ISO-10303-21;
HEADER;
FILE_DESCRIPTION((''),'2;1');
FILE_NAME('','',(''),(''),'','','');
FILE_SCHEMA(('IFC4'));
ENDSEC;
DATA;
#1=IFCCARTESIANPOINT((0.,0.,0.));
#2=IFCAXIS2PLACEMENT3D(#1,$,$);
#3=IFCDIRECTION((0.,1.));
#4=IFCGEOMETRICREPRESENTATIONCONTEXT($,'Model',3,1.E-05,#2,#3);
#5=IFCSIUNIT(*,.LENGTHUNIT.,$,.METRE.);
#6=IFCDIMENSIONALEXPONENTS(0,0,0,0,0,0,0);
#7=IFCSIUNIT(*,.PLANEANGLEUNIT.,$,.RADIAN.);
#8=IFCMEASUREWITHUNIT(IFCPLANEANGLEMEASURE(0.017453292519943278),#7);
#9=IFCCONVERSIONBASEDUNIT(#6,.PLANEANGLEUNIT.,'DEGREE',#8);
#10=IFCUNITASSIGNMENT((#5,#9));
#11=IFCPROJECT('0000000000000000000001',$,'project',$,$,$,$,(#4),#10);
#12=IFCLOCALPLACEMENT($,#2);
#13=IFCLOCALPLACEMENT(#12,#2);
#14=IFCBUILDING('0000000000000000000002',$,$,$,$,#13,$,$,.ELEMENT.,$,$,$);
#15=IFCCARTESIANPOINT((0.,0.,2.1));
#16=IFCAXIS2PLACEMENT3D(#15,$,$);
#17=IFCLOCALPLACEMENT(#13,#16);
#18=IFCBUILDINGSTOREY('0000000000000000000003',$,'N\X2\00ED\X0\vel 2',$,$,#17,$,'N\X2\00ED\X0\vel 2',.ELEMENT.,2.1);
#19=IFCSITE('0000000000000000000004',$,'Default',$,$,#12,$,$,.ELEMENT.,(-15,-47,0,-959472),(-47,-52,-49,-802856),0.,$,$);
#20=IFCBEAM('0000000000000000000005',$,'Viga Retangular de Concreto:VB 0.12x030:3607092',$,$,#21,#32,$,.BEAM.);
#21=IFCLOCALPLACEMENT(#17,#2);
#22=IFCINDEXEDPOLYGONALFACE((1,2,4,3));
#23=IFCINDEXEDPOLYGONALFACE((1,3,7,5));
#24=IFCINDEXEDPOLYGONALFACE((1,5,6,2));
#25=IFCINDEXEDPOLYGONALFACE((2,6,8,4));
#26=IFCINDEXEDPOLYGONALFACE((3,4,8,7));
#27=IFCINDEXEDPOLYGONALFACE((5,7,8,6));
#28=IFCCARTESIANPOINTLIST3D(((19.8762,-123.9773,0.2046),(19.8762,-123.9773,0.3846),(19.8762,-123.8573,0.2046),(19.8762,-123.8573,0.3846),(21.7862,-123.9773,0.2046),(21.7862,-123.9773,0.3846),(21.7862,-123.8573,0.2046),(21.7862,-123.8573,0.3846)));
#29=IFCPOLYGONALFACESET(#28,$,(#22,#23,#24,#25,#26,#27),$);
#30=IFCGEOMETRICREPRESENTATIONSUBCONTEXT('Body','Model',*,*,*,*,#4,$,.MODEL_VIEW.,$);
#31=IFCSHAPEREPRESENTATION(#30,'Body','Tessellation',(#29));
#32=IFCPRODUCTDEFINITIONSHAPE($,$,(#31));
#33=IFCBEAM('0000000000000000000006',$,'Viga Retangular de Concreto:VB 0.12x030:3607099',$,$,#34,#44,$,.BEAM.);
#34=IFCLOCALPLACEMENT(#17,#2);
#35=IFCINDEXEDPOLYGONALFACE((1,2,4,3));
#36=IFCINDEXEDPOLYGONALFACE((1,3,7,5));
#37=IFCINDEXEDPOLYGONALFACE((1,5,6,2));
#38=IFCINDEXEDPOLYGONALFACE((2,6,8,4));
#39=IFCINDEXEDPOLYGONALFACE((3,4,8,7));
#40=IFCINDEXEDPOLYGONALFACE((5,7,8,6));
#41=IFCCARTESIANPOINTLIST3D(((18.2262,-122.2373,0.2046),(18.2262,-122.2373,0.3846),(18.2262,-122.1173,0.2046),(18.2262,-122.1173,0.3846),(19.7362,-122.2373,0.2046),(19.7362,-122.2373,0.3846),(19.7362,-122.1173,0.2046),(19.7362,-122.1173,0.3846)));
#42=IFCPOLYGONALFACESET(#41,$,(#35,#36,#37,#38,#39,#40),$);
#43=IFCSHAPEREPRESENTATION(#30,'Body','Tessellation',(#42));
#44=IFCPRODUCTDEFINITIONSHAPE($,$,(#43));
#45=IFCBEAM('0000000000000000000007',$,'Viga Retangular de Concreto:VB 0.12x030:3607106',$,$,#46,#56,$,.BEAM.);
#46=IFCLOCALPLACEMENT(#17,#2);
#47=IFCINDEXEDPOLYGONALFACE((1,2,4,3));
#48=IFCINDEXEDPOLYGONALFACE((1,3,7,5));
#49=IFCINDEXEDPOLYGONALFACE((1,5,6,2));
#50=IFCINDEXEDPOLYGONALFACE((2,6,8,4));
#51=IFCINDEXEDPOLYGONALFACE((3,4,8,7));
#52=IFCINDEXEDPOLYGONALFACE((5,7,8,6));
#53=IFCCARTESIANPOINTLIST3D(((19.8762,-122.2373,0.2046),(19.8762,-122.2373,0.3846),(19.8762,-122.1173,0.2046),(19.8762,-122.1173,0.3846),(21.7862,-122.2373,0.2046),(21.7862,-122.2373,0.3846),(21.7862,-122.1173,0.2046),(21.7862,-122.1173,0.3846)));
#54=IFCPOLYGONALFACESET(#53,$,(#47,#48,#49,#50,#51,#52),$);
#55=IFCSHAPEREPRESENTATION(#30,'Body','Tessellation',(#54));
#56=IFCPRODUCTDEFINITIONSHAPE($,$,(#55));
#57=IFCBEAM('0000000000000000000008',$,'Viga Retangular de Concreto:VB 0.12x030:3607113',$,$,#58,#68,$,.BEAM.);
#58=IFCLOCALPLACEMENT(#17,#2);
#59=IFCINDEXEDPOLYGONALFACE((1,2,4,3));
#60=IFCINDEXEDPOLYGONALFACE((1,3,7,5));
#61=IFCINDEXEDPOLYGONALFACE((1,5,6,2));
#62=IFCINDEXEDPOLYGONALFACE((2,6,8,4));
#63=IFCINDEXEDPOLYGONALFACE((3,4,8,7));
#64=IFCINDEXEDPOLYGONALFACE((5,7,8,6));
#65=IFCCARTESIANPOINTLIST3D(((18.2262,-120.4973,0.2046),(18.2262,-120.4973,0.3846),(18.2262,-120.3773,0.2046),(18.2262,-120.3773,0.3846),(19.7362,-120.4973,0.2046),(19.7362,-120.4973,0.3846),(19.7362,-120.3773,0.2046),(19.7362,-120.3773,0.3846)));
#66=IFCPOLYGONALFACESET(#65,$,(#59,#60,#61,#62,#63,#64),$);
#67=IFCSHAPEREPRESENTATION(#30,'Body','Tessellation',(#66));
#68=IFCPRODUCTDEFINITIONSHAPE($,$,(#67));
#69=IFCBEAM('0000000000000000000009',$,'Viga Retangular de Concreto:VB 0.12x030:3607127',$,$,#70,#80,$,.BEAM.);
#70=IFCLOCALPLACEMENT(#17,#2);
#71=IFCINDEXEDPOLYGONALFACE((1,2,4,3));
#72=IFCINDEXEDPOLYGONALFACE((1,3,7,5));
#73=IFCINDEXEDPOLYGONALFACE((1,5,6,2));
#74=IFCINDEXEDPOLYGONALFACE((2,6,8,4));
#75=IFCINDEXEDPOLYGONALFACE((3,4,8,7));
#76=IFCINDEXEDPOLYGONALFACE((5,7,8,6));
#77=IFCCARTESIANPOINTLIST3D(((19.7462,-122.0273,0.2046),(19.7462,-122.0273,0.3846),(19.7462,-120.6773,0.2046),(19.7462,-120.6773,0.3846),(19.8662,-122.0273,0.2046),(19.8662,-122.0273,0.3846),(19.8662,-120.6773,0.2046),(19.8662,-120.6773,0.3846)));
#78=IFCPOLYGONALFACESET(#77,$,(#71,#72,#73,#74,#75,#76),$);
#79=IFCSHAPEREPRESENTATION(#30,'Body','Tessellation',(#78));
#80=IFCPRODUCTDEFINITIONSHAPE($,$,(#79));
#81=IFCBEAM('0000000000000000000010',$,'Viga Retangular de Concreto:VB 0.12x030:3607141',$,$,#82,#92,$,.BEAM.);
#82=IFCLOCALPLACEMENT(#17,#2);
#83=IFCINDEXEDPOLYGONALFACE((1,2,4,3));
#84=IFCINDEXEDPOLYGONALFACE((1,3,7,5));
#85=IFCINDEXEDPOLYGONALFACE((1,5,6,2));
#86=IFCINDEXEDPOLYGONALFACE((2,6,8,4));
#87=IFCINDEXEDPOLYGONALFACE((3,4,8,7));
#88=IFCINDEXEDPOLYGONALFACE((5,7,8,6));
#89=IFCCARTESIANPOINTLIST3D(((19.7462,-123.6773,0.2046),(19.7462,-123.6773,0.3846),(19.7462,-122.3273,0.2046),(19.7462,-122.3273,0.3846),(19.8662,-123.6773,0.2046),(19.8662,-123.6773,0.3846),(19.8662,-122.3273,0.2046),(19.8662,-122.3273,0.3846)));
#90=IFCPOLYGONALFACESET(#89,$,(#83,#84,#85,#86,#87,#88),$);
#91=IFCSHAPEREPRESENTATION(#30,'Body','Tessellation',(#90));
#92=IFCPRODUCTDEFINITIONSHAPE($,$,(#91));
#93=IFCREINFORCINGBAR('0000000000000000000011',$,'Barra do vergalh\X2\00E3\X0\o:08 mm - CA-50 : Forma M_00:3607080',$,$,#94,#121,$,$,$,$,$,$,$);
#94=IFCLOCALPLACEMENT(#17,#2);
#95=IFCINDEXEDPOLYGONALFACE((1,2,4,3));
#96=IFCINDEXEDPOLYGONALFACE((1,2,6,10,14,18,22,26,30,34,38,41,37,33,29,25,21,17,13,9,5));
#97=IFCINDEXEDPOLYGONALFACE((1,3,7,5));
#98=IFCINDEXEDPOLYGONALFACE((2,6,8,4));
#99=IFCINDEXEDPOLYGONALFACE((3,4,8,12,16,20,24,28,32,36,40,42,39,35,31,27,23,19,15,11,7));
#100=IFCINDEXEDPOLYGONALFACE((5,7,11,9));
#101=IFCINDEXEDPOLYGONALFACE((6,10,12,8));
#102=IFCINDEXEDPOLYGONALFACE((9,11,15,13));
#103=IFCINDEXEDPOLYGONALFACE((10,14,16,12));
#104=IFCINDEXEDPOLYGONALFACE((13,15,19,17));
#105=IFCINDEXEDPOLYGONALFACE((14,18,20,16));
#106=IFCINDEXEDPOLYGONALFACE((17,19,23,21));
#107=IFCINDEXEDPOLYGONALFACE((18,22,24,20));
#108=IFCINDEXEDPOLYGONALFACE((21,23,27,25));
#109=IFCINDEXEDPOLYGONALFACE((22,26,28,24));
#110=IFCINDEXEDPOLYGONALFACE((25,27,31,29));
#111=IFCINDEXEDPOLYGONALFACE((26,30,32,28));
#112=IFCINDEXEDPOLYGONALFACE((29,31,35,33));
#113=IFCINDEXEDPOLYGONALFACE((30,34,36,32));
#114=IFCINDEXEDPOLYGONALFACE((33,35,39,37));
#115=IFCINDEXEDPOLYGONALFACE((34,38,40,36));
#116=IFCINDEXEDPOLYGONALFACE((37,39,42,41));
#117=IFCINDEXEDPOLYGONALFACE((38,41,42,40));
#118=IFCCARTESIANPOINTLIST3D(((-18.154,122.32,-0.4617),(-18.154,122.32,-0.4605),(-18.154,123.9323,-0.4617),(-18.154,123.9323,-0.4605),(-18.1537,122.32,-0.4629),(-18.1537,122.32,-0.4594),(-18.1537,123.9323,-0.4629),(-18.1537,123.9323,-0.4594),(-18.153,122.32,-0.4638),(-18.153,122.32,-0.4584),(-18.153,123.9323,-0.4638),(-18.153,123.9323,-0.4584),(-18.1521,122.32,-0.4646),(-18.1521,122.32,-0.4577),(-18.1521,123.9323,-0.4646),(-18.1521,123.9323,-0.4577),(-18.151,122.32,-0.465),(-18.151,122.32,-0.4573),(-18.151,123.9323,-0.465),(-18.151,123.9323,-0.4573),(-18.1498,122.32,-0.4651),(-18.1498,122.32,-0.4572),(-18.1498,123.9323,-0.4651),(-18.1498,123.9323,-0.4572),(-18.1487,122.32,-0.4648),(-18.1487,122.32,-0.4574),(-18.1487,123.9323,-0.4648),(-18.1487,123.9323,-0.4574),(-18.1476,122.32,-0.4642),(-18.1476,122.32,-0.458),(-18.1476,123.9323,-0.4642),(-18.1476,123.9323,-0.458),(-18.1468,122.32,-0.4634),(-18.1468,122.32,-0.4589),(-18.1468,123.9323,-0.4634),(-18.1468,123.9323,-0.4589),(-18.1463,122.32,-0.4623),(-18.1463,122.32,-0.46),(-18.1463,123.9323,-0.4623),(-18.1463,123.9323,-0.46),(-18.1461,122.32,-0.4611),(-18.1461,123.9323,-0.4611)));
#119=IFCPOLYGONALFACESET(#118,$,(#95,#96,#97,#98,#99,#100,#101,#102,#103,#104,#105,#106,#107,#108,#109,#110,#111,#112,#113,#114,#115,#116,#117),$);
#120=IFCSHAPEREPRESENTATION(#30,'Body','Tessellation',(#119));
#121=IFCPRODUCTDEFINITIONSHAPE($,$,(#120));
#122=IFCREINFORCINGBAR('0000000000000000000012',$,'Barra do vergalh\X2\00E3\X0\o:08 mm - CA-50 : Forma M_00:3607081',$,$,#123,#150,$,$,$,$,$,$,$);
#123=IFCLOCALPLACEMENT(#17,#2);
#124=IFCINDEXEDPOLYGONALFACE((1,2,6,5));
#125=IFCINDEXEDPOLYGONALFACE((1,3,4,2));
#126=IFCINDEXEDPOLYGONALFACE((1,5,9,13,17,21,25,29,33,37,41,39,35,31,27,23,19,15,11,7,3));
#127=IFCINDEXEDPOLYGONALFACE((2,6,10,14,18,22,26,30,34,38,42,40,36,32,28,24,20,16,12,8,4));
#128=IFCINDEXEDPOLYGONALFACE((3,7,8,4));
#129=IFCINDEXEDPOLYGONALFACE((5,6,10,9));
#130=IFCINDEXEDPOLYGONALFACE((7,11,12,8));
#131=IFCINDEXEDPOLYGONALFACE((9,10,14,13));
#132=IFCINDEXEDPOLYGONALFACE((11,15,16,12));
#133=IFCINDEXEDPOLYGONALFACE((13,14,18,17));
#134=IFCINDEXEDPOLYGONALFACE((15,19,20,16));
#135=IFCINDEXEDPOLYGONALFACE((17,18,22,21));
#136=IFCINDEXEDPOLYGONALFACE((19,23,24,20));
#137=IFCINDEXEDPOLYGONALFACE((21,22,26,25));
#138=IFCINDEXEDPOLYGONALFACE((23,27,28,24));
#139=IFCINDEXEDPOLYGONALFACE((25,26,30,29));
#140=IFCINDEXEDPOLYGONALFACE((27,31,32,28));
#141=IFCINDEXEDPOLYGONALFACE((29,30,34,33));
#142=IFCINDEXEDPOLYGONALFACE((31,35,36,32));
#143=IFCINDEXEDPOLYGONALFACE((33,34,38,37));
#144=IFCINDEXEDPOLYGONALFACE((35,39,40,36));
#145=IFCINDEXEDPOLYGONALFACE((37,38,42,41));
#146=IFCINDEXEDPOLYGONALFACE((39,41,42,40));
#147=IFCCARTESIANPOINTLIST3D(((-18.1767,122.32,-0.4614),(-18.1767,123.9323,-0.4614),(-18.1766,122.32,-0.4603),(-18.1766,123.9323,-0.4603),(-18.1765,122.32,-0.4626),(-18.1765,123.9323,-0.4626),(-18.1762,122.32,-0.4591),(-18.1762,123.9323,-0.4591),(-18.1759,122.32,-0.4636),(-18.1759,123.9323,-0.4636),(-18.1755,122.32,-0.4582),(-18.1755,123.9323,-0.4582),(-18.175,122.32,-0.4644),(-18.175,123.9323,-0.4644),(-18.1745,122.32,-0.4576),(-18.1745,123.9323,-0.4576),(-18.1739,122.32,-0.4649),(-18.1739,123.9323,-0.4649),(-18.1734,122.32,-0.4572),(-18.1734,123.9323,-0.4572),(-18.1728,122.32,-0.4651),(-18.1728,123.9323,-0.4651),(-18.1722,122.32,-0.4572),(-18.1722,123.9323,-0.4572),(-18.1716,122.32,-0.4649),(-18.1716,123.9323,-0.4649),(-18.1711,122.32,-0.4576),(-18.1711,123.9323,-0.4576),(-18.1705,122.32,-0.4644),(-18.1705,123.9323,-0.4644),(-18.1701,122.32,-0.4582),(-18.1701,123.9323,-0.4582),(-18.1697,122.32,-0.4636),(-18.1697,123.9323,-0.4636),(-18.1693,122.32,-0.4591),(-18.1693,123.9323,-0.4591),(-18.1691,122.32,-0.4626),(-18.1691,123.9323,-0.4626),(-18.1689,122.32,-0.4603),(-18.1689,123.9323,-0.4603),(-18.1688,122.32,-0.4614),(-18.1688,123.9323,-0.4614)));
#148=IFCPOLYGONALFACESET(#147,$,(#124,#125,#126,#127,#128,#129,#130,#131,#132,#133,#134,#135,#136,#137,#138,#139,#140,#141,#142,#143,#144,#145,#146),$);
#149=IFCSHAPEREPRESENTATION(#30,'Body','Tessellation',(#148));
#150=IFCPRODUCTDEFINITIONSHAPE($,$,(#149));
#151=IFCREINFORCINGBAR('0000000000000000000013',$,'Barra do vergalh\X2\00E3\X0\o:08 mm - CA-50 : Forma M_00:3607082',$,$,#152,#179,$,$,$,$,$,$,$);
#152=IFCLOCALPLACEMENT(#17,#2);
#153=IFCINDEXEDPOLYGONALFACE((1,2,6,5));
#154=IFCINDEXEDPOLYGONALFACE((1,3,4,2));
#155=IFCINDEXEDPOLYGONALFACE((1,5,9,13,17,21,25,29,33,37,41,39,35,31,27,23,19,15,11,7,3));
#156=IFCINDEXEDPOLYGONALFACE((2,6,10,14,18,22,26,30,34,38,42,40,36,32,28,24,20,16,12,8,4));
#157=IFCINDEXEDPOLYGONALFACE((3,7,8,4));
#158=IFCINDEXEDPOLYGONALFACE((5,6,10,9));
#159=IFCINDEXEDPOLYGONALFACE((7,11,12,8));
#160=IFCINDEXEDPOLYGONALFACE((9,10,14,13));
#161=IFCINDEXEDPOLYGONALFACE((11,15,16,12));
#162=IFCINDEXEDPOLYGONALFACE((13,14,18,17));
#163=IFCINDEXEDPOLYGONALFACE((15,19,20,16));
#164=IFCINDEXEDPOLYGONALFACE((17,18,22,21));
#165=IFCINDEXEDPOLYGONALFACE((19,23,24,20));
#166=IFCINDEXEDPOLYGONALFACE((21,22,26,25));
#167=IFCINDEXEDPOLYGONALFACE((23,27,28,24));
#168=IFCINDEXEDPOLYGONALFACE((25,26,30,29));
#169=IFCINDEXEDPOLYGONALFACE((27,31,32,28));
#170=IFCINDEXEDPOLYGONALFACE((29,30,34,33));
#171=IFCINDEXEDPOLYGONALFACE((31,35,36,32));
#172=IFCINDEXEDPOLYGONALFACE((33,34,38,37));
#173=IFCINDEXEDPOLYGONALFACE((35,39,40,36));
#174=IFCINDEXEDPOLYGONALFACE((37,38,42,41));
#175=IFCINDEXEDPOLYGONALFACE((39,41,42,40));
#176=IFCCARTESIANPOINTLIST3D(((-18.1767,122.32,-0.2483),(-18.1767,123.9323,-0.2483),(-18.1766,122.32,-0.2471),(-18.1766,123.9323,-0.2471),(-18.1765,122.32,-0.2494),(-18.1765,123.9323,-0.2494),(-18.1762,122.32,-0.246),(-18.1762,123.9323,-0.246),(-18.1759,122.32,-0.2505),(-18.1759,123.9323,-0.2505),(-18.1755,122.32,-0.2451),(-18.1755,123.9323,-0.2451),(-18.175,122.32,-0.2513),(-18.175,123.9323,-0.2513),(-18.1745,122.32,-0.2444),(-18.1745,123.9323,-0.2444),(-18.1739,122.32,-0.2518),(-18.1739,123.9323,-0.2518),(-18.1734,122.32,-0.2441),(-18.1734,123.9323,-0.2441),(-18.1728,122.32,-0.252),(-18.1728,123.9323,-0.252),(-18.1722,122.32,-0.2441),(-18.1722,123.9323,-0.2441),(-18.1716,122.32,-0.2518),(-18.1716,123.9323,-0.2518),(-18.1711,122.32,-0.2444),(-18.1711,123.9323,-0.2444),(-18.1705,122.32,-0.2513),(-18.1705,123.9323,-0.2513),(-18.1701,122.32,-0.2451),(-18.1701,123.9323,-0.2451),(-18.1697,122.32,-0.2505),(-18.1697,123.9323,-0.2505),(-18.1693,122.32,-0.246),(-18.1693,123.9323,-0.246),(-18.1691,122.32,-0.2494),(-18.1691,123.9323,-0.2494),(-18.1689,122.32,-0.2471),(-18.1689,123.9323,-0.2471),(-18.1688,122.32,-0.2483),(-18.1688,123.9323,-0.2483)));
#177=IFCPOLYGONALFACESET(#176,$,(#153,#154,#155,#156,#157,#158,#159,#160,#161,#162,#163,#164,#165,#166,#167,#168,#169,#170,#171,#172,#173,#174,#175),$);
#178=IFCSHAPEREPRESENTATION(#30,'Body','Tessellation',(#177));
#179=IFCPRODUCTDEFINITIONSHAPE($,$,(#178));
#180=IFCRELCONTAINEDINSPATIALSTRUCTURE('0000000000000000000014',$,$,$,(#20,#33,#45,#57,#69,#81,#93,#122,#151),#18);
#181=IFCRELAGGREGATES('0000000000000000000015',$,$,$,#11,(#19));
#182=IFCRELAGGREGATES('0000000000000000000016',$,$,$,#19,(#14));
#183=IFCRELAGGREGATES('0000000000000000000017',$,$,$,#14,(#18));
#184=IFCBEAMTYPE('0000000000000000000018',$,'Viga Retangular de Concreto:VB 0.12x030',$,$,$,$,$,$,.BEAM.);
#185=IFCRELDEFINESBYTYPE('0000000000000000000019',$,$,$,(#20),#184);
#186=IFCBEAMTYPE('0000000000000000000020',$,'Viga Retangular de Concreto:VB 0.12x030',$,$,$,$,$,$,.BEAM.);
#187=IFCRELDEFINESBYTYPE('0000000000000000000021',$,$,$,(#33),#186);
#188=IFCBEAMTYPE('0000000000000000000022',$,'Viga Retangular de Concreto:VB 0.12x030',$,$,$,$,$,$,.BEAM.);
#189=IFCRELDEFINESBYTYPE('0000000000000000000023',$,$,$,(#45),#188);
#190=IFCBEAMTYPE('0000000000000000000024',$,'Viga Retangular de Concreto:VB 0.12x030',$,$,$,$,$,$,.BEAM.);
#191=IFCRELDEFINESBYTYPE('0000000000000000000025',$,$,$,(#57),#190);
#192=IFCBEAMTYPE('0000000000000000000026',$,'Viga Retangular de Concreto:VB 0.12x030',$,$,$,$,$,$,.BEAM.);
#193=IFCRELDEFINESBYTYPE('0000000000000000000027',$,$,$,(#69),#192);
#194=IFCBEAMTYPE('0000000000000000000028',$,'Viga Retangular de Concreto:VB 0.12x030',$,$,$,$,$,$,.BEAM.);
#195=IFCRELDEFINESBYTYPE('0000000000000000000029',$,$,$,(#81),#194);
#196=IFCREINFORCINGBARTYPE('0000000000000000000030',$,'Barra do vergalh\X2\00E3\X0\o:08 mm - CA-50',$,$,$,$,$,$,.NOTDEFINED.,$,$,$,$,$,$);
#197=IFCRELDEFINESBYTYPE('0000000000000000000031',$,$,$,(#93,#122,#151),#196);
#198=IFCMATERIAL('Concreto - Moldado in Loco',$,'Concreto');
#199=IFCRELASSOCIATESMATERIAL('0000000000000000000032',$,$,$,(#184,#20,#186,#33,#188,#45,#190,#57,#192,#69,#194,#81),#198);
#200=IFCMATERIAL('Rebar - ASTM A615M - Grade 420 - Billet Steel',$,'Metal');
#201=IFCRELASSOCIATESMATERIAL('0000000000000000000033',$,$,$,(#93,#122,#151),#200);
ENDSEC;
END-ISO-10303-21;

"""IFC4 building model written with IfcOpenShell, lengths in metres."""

from ifc_helpers import new_model, entity, si_unit, converted_unit, direction, frame, origin, place, context, subcontext, project, spatial, indexed_curve, outline, extrude, source, transform, mapped, material, type_object, type_shapes, element, save


model = new_model("IFC4")

# Units and contexts
model_context = context("Model", 3, precision=1e-05, world=origin(), true_north=direction((0.0, 1.0)))
body_context = subcontext(model_context, "Body", "Model", "MODEL_VIEW")
ifc_project = project(units=[si_unit("LENGTHUNIT", "METRE"), converted_unit("PLANEANGLEUNIT", "DEGREE", entity("IfcPlaneAngleMeasure", 0.017453292519943278), si_unit("PLANEANGLEUNIT", "RADIAN"), dimensions=[0, 0, 0, 0, 0, 0, 0])], contexts=[model_context])

# Site, building, storey
site_placement = place(None, origin())
site = spatial("IfcSite", under=ifc_project, at=site_placement, Name="Default", CompositionType="ELEMENT", RefLatitude=(-15, -47, 0, -959472), RefLongitude=(-47, -52, -49, -802856), RefElevation=0.0)
building_placement = place(site_placement, origin())
building = spatial("IfcBuilding", under=site, at=building_placement, CompositionType="ELEMENT")
storey_placement = place(building_placement, frame((0.0, 0.0, 2.1)))
storey = spatial("IfcBuildingStorey", under=building, at=storey_placement, Name="Nível 2", LongName="Nível 2", CompositionType="ELEMENT", Elevation=2.1)

# Beams
ifc_material_1 = material(Name="Concreto - Moldado in Loco", Category="Concreto")
beam_type_1 = type_object("IfcBeamType", Name="Viga Retangular de Concreto:VB 0.12x030", PredefinedType="BEAM", material=ifc_material_1)
shared_shape_1 = source(origin(), body_context, "Body", "SweptSolid", [
    extrude(outline(indexed_curve([(-0.09, -0.06), (0.09, -0.06), (0.09, 0.06), (-0.09, 0.06), (-0.09, -0.06)], self_intersect=False)), frame((19.8762, -123.9173, 2.3946), z_axis=(1.0, 0.0, 0.0), x_axis=(0.0, 0.0, -1.0)), (0.0, 0.0, 1.0), 1.91),
])
type_shapes(beam_type_1, [shared_shape_1])
beam_1_placement = place(storey_placement, frame((0.0, 0.0, -2.1)))
element("IfcBeam", 1, at=beam_1_placement, inside=storey, type_object=beam_type_1, material=ifc_material_1, Name="Viga Retangular de Concreto:VB 0.12x030:3607092", PredefinedType="BEAM", context=body_context, shape_type="MappedRepresentation", body=[
    mapped(shared_shape_1, transform((0.0, 0.0, 0.0), scale=1.0)),
])
beam_type_2 = type_object("IfcBeamType", Name="Viga Retangular de Concreto:VB 0.12x030", PredefinedType="BEAM", material=ifc_material_1)
shared_shape_2 = source(origin(), body_context, "Body", "SweptSolid", [
    extrude(outline(indexed_curve([(-0.09, -0.06), (0.09, -0.06), (0.09, 0.06), (-0.09, 0.06), (-0.09, -0.06)], self_intersect=False)), frame((18.2262, -122.1773, 2.3946), z_axis=(1.0, 0.0, 0.0), x_axis=(0.0, 0.0, -1.0)), (0.0, 0.0, 1.0), 1.51),
])
type_shapes(beam_type_2, [shared_shape_2])
beam_2_placement = place(storey_placement, frame((0.0, 0.0, -2.1)))
element("IfcBeam", 2, at=beam_2_placement, inside=storey, type_object=beam_type_2, material=ifc_material_1, Name="Viga Retangular de Concreto:VB 0.12x030:3607099", PredefinedType="BEAM", context=body_context, shape_type="MappedRepresentation", body=[
    mapped(shared_shape_2, transform((0.0, 0.0, 0.0), scale=1.0)),
])
beam_type_3 = type_object("IfcBeamType", Name="Viga Retangular de Concreto:VB 0.12x030", PredefinedType="BEAM", material=ifc_material_1)
shared_shape_3 = source(origin(), body_context, "Body", "SweptSolid", [
    extrude(outline(indexed_curve([(-0.09, -0.06), (0.09, -0.06), (0.09, 0.06), (-0.09, 0.06), (-0.09, -0.06)], self_intersect=False)), frame((19.8762, -122.1773, 2.3946), z_axis=(1.0, 0.0, 0.0), x_axis=(0.0, 0.0, -1.0)), (0.0, 0.0, 1.0), 1.91),
])
type_shapes(beam_type_3, [shared_shape_3])
beam_3_placement = place(storey_placement, frame((0.0, 0.0, -2.1)))
element("IfcBeam", 3, at=beam_3_placement, inside=storey, type_object=beam_type_3, material=ifc_material_1, Name="Viga Retangular de Concreto:VB 0.12x030:3607106", PredefinedType="BEAM", context=body_context, shape_type="MappedRepresentation", body=[
    mapped(shared_shape_3, transform((0.0, 0.0, 0.0), scale=1.0)),
])
beam_type_4 = type_object("IfcBeamType", Name="Viga Retangular de Concreto:VB 0.12x030", PredefinedType="BEAM", material=ifc_material_1)
shared_shape_4 = source(origin(), body_context, "Body", "SweptSolid", [
    extrude(outline(indexed_curve([(-0.09, -0.06), (0.09, -0.06), (0.09, 0.06), (-0.09, 0.06), (-0.09, -0.06)], self_intersect=False)), frame((18.2262, -120.4373, 2.3946), z_axis=(1.0, 0.0, 0.0), x_axis=(0.0, 0.0, -1.0)), (0.0, 0.0, 1.0), 1.51),
])
type_shapes(beam_type_4, [shared_shape_4])
beam_4_placement = place(storey_placement, frame((0.0, 0.0, -2.1)))
element("IfcBeam", 4, at=beam_4_placement, inside=storey, type_object=beam_type_4, material=ifc_material_1, Name="Viga Retangular de Concreto:VB 0.12x030:3607113", PredefinedType="BEAM", context=body_context, shape_type="MappedRepresentation", body=[
    mapped(shared_shape_4, transform((0.0, 0.0, 0.0), scale=1.0)),
])
beam_type_5 = type_object("IfcBeamType", Name="Viga Retangular de Concreto:VB 0.12x030", PredefinedType="BEAM", material=ifc_material_1)
shared_shape_5 = source(origin(), body_context, "Body", "SweptSolid", [
    extrude(outline(indexed_curve([(-0.06, -0.09), (0.06, -0.09), (0.06, 0.09), (-0.06, 0.09), (-0.06, -0.09)], self_intersect=False)), frame((19.8062, -122.0273, 2.3946), z_axis=(0.0, 1.0, 0.0), x_axis=(-1.0, 0.0, 0.0)), (0.0, 0.0, 1.0), 1.35),
])
type_shapes(beam_type_5, [shared_shape_5])
beam_5_placement = place(storey_placement, frame((0.0, 0.0, -2.1)))
element("IfcBeam", 5, at=beam_5_placement, inside=storey, type_object=beam_type_5, material=ifc_material_1, Name="Viga Retangular de Concreto:VB 0.12x030:3607127", PredefinedType="BEAM", context=body_context, shape_type="MappedRepresentation", body=[
    mapped(shared_shape_5, transform((0.0, 0.0, 0.0), scale=1.0)),
])
beam_type_6 = type_object("IfcBeamType", Name="Viga Retangular de Concreto:VB 0.12x030", PredefinedType="BEAM", material=ifc_material_1)
shared_shape_6 = source(origin(), body_context, "Body", "SweptSolid", [
    extrude(outline(indexed_curve([(-0.06, -0.09), (0.06, -0.09), (0.06, 0.09), (-0.06, 0.09), (-0.06, -0.09)], self_intersect=False)), frame((19.8062, -123.6773, 2.3946), z_axis=(0.0, 1.0, 0.0), x_axis=(-1.0, 0.0, 0.0)), (0.0, 0.0, 1.0), 1.35),
])
type_shapes(beam_type_6, [shared_shape_6])
beam_6_placement = place(storey_placement, frame((0.0, 0.0, -2.1)))
element("IfcBeam", 6, at=beam_6_placement, inside=storey, type_object=beam_type_6, material=ifc_material_1, Name="Viga Retangular de Concreto:VB 0.12x030:3607141", PredefinedType="BEAM", context=body_context, shape_type="MappedRepresentation", body=[
    mapped(shared_shape_6, transform((0.0, 0.0, 0.0), scale=1.0)),
])

# Reinforcing bars
ifc_material_2 = material(Name="Rebar - ASTM A615M - Grade 420 - Billet Steel", Category="Metal")
reinforcing_bar_type_1 = type_object("IfcReinforcingBarType", Name="Barra do vergalhão:08 mm - CA-50", PredefinedType="NOTDEFINED")
reinforcing_bar_1_placement = place(storey_placement, origin())
element("IfcReinforcingBar", 7, at=reinforcing_bar_1_placement, inside=storey, type_object=reinforcing_bar_type_1, material=ifc_material_2, Name="Barra do vergalhão:08 mm - CA-50 : Forma M_00:3607080", context=body_context, shape_type="AdvancedSweptSolid", body=[
    entity("IfcSweptDiskSolid", entity("IfcIndexedPolyCurve", entity("IfcCartesianPointList3D", [[18.1501, -123.9323, 0.4611], [18.1501, -122.32, 0.4611]]), None, False), 0.004, None, 0.0, 1.0),
])
reinforcing_bar_2_placement = place(storey_placement, origin())
element("IfcReinforcingBar", 8, at=reinforcing_bar_2_placement, inside=storey, type_object=reinforcing_bar_type_1, material=ifc_material_2, Name="Barra do vergalhão:08 mm - CA-50 : Forma M_00:3607081", context=body_context, shape_type="AdvancedSweptSolid", body=[
    entity("IfcSweptDiskSolid", entity("IfcIndexedPolyCurve", entity("IfcCartesianPointList3D", [[18.1728, -122.32, 0.4611], [18.1728, -123.9323, 0.4611]]), None, False), 0.004, None, 0.0, 1.0),
])
reinforcing_bar_3_placement = place(storey_placement, origin())
element("IfcReinforcingBar", 9, at=reinforcing_bar_3_placement, inside=storey, type_object=reinforcing_bar_type_1, material=ifc_material_2, Name="Barra do vergalhão:08 mm - CA-50 : Forma M_00:3607082", context=body_context, shape_type="AdvancedSweptSolid", body=[
    entity("IfcSweptDiskSolid", entity("IfcIndexedPolyCurve", entity("IfcCartesianPointList3D", [[18.1728, -122.32, 0.248], [18.1728, -123.9323, 0.248]]), None, False), 0.004, None, 0.0, 1.0),
])

save(model, "model.ifc")
